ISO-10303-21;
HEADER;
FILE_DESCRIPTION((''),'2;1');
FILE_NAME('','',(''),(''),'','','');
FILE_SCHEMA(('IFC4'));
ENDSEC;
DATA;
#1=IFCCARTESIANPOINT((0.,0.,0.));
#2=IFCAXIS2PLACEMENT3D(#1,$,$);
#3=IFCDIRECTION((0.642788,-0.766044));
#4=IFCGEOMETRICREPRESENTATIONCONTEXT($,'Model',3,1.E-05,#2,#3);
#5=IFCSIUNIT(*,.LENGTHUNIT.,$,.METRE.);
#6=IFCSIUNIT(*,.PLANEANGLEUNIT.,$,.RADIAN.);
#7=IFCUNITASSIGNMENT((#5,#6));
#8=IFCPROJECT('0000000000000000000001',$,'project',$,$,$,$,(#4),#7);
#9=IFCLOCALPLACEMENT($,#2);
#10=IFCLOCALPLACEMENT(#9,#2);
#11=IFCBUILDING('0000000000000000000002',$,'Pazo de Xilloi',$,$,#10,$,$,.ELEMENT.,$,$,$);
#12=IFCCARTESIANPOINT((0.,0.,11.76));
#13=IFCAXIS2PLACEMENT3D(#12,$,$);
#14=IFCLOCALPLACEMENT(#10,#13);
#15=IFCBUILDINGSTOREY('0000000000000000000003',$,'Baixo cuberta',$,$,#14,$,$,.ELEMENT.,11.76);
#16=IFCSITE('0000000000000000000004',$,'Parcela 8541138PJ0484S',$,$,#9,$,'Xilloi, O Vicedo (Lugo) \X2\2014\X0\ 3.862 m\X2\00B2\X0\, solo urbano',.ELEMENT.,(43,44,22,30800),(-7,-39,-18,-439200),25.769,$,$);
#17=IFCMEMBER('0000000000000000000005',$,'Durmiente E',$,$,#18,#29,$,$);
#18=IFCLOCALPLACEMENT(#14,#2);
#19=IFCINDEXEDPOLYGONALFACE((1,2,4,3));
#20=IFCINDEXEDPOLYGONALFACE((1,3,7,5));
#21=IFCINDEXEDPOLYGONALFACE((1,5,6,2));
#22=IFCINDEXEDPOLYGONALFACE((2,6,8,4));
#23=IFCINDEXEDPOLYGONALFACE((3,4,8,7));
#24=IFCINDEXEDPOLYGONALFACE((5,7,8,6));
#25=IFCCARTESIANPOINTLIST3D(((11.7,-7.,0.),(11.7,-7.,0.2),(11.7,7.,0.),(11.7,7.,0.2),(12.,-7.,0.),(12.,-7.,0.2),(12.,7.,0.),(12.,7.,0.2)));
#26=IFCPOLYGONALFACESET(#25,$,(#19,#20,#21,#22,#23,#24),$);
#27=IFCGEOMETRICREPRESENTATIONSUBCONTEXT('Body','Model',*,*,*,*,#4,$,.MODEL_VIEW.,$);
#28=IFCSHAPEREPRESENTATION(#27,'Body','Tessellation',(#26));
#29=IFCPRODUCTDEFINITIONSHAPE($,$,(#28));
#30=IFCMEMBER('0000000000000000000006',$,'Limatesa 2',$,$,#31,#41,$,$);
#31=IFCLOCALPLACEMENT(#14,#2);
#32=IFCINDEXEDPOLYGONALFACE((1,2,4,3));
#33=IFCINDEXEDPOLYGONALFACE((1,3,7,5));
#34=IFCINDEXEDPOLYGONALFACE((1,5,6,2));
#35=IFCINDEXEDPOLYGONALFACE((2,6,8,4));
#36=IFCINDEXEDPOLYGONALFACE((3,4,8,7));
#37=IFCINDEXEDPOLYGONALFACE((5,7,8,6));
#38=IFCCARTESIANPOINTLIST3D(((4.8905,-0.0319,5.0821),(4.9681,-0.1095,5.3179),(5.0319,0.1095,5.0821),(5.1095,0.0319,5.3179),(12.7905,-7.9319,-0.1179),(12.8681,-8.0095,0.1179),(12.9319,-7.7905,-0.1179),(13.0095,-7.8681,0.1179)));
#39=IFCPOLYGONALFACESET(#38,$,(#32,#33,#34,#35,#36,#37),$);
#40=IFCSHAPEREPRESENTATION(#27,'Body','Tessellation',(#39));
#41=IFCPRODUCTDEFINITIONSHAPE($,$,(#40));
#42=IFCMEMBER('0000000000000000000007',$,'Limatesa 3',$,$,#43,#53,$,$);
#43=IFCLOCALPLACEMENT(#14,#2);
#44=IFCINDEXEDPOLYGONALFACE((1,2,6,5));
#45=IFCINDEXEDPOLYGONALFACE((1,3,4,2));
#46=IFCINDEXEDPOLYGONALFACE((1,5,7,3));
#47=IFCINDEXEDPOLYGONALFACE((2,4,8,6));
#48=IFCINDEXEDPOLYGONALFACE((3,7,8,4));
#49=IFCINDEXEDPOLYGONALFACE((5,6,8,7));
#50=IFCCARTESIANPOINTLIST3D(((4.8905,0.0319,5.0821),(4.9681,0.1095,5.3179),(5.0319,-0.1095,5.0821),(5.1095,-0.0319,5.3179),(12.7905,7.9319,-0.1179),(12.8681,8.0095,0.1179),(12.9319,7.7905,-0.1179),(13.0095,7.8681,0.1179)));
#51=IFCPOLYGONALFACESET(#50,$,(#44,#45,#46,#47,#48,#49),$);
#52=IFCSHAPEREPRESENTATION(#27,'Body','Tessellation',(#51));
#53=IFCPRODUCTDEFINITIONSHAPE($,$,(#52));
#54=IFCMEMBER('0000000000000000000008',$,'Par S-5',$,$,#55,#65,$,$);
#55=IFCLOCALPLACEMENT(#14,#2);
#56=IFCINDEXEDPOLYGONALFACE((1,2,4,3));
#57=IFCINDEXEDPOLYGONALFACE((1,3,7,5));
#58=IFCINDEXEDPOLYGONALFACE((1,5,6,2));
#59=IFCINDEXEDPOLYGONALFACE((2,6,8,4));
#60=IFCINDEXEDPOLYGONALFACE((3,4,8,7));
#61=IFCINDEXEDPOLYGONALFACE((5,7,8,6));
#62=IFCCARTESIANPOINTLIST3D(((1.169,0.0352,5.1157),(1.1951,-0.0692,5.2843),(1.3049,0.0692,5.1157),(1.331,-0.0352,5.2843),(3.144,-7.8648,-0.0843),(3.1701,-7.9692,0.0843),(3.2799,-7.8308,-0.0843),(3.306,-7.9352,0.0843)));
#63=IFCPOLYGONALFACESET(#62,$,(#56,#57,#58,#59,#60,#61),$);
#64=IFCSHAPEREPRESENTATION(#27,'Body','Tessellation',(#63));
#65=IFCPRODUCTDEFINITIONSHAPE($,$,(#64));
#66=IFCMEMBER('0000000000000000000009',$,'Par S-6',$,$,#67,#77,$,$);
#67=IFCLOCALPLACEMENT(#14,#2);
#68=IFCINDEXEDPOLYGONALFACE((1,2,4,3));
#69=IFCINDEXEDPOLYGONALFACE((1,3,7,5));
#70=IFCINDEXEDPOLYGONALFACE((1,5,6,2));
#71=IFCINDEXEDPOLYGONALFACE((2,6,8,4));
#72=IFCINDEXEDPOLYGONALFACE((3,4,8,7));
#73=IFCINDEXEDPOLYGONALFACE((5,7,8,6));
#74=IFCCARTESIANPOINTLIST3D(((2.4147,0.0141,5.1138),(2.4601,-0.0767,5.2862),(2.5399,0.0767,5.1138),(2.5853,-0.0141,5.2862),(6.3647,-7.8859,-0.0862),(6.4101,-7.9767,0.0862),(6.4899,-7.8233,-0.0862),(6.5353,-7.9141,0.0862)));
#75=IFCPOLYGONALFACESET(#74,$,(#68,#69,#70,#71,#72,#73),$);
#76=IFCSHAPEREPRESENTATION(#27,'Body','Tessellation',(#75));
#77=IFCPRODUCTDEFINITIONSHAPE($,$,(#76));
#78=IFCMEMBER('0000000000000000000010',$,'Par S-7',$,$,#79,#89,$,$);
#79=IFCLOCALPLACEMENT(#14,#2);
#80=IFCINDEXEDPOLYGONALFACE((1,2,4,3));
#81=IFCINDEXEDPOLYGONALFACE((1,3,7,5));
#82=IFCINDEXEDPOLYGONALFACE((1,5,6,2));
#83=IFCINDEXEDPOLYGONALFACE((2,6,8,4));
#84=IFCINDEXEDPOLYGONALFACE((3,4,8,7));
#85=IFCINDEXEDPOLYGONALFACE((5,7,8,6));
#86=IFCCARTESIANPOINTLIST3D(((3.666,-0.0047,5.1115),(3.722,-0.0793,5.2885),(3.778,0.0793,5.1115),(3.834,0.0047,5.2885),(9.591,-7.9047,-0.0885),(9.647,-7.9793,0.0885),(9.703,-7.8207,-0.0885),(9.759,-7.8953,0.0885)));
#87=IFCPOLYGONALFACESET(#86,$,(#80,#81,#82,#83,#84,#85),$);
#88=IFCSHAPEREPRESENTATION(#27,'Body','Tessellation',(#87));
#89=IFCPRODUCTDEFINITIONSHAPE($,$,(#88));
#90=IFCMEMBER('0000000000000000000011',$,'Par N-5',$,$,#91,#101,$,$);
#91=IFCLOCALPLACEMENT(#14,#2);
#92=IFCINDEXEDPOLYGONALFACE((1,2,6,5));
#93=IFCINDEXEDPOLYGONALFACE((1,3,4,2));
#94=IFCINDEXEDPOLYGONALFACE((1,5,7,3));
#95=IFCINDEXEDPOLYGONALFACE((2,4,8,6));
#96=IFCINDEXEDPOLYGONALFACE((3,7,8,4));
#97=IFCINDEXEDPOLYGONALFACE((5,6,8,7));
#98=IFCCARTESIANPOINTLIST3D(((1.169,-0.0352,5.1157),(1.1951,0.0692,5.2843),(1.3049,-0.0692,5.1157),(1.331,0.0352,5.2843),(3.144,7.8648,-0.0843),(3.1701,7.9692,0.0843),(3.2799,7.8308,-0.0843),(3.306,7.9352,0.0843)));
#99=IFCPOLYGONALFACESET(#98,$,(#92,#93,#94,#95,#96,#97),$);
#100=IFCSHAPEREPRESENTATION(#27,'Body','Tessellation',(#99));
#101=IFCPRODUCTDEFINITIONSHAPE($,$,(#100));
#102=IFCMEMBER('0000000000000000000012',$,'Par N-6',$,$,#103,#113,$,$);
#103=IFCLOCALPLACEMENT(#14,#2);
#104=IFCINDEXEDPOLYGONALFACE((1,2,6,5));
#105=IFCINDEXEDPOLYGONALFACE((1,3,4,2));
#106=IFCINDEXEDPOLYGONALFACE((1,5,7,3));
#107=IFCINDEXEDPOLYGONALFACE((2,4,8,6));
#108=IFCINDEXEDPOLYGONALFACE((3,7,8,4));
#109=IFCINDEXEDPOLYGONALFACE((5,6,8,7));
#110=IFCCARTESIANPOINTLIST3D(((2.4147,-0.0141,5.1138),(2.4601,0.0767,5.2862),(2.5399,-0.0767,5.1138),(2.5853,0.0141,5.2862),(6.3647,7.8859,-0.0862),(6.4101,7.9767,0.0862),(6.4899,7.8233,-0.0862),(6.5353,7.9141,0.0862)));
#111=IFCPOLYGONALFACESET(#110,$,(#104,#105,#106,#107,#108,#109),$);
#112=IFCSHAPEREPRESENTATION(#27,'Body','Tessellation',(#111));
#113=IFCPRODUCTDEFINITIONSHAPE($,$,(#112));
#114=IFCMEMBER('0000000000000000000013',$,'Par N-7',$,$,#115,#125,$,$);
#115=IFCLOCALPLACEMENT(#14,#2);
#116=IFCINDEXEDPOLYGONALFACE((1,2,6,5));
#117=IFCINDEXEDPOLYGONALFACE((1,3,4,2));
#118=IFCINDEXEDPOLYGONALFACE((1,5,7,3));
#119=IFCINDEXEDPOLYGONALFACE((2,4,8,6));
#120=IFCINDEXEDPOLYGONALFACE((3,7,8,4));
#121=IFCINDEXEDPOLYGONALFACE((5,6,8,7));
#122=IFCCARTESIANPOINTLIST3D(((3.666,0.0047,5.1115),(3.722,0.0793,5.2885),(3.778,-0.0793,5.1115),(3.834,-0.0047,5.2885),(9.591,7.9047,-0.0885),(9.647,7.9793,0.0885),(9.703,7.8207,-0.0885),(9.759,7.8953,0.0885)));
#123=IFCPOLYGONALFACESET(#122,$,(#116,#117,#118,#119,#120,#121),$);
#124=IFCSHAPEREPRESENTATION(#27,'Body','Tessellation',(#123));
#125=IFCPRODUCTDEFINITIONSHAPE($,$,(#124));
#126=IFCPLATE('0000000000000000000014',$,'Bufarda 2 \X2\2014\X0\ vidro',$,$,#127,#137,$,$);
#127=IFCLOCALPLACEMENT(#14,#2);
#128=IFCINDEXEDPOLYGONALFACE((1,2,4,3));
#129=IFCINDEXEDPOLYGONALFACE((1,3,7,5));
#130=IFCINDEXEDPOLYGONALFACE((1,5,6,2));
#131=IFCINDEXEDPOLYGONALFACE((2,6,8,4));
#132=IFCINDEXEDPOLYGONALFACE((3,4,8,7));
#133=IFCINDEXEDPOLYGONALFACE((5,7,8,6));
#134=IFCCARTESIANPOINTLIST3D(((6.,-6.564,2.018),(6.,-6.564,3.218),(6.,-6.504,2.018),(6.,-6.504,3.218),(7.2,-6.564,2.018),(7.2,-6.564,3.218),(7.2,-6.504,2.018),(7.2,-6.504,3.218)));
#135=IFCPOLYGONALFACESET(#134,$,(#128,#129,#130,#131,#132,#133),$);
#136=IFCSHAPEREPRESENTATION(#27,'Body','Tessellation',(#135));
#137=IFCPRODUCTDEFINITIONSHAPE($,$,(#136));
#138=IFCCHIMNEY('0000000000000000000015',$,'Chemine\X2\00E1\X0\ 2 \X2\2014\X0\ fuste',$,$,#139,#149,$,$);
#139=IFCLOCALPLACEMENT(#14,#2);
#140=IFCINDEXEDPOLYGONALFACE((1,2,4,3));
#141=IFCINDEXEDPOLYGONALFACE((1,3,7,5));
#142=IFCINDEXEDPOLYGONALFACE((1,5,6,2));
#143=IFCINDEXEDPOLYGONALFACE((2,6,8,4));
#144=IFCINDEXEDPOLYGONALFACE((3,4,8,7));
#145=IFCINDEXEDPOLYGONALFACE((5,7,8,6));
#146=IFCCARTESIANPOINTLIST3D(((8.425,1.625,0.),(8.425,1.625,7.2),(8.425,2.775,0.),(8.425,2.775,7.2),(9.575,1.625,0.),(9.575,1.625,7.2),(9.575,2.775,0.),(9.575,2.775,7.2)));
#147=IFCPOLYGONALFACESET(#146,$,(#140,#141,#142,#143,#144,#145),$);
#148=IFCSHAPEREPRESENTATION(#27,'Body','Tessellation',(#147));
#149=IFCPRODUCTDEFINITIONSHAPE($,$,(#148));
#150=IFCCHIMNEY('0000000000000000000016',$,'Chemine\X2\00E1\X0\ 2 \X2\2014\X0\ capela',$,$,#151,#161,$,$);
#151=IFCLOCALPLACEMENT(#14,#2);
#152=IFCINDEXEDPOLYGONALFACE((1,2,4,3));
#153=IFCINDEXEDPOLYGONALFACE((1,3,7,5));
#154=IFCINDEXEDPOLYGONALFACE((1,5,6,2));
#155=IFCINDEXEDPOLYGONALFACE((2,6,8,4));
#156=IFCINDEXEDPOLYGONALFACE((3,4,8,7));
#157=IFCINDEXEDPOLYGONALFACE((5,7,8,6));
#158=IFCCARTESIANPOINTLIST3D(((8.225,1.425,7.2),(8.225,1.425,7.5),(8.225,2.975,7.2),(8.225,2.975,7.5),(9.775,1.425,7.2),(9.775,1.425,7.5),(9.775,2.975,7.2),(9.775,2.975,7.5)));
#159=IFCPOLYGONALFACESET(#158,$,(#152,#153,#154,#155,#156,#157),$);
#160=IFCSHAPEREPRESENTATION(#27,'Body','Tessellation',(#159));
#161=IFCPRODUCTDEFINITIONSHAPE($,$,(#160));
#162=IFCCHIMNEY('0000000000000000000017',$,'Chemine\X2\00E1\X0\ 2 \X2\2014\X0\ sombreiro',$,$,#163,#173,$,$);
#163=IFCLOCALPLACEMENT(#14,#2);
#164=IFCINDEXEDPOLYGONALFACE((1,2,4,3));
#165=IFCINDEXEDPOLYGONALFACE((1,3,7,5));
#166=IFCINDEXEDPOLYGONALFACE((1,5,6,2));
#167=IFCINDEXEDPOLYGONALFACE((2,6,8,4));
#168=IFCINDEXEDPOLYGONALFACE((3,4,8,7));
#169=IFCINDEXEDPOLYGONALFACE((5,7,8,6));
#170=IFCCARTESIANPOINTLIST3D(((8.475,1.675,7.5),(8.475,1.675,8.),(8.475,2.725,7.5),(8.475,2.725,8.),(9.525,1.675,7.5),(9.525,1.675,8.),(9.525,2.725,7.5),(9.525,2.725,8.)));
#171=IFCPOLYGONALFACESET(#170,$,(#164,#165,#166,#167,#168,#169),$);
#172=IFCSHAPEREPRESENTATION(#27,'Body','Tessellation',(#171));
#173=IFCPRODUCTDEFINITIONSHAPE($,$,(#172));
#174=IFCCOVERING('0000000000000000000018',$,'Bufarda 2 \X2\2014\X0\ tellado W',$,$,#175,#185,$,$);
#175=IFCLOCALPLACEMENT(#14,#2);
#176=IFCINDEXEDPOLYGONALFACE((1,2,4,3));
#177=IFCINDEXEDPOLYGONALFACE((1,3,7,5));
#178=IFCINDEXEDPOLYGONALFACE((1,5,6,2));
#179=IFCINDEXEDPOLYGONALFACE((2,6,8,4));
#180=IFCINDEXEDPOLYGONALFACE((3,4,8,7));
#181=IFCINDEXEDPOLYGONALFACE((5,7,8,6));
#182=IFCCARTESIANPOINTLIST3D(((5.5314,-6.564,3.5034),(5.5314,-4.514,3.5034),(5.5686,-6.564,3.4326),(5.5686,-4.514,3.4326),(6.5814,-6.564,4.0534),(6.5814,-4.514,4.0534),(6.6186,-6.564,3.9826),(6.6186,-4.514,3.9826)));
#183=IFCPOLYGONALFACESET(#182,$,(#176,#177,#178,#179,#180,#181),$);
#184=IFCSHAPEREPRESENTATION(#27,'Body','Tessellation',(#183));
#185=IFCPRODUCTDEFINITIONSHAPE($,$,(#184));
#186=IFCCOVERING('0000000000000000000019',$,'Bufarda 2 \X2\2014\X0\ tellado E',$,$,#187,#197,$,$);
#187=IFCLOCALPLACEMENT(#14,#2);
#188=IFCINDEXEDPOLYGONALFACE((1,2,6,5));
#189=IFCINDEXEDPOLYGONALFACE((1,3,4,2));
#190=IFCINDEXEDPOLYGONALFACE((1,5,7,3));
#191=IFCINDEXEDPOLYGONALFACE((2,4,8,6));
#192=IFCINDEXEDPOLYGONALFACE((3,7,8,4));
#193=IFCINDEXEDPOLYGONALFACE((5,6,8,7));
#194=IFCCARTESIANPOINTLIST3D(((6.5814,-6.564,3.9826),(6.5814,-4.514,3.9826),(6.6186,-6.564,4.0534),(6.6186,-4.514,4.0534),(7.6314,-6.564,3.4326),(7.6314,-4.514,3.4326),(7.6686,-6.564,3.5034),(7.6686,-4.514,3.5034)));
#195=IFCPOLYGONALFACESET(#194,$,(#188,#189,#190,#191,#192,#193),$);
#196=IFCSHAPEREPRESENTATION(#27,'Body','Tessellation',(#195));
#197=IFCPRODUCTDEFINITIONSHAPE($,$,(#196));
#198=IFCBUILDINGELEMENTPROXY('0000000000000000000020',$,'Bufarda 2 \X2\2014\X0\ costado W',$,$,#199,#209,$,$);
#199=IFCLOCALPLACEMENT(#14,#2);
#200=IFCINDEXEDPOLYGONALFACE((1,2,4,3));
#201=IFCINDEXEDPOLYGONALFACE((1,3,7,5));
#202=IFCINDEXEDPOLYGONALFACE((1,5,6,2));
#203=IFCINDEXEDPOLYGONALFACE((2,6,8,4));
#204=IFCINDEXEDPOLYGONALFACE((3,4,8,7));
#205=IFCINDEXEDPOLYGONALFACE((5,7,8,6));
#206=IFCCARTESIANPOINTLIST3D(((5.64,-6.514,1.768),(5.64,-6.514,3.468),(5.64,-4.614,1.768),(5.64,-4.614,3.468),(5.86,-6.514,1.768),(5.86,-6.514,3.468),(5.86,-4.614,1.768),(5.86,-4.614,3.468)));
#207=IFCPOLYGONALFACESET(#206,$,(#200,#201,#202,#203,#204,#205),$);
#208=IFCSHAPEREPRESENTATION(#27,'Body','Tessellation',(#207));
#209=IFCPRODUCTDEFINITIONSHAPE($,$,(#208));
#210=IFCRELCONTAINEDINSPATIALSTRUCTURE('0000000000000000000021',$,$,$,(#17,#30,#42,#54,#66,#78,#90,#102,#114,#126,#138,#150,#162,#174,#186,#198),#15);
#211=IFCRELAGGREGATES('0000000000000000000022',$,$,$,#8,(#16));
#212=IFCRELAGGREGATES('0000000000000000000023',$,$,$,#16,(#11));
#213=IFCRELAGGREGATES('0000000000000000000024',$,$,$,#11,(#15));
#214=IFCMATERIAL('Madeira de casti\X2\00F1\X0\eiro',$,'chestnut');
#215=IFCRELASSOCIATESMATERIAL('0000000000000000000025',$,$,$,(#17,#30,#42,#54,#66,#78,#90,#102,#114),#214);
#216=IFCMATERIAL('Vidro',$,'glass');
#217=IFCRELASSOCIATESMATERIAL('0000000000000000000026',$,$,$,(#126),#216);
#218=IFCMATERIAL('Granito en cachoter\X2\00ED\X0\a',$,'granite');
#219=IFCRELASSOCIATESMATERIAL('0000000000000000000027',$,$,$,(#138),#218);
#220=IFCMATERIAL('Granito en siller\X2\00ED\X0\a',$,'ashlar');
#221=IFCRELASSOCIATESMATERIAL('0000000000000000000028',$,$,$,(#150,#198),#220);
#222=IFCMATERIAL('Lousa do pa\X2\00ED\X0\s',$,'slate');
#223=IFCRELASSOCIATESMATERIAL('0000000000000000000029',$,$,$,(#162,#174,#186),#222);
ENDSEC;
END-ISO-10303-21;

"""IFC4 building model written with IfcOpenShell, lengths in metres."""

from ifc_helpers import new_model, si_unit, direction, frame, origin, origin_2d, place, context, subcontext, project, spatial, polyline, rectangle, outline, extrude, material, element, save


model = new_model("IFC4")

# Units and contexts
model_context = context("Model", 3, precision=1e-05, world=origin(), true_north=direction((0.642788, -0.766044)))
body_context = subcontext(model_context, "Body", "Model", "MODEL_VIEW")
ifc_project = project(units=[si_unit("LENGTHUNIT", "METRE"), si_unit("PLANEANGLEUNIT", "RADIAN")], contexts=[model_context])

# Site, building, storey
site_placement = place(None, origin())
site = spatial("IfcSite", under=ifc_project, at=site_placement, Name="Parcela 8541138PJ0484S", LongName="Xilloi, O Vicedo (Lugo) — 3.862 m², solo urbano", CompositionType="ELEMENT", RefLatitude=(43, 44, 22, 30800), RefLongitude=(-7, -39, -18, -439200), RefElevation=25.769)
building_placement = place(site_placement, origin())
building = spatial("IfcBuilding", under=site, at=building_placement, Name="Pazo de Xilloi", CompositionType="ELEMENT")
storey_placement = place(building_placement, frame((0.0, 0.0, 11.76)))
storey = spatial("IfcBuildingStorey", under=building, at=storey_placement, Name="Baixo cuberta", CompositionType="ELEMENT", Elevation=11.76)

# Members
ifc_material_1 = material(Name="Madeira de castiñeiro", Category="chestnut")
member_1_placement = place(storey_placement, frame((11.85, 0.0, 0.1)))
element("IfcMember", 1, at=member_1_placement, inside=storey, material=ifc_material_1, Name="Durmiente E", context=body_context, shape_type="SweptSolid", body=[
    extrude(rectangle(XDim=0.3, YDim=14.0, at=origin_2d()), frame((0.0, 0.0, -0.1)), (0.0, 0.0, 1.0), 0.2),
])
for number, where, z_axis, x_axis, name in (
    (2, (8.95, -3.95, 2.6), (0.298378, -0.298378, 0.90661), (-0.64107, 0.64107, 0.42197), "Limatesa 2"),
    (3, (8.95, 3.95, 2.6), (0.298378, 0.298378, 0.90661), (-0.64107, -0.64107, 0.42197), "Limatesa 3"),
):
    element("IfcMember", number, at=place(storey_placement, frame(where, z_axis=z_axis, x_axis=x_axis)), inside=storey, material=ifc_material_1, Name=name, context=body_context, shape_type="SweptSolid", body=[
        extrude(rectangle(XDim=12.3231, YDim=0.2, at=origin_2d()), frame((0.0, 0.0, -0.13)), (0.0, 0.0, 1.0), 0.26),
    ])
member_2_placement = place(storey_placement, frame((2.2375, -3.95, 2.6), z_axis=(0.130533, -0.522132, 0.842816), x_axis=(-0.204413, 0.817652, 0.538201)))
element("IfcMember", 4, at=member_2_placement, inside=storey, material=ifc_material_1, Name="Par S-5", context=body_context, shape_type="SweptSolid", body=[
    extrude(rectangle(XDim=9.6618, YDim=0.14, at=origin_2d()), frame((0.0, 0.0, -0.1)), (0.0, 0.0, 1.0), 0.2),
])
member_3_placement = place(storey_placement, frame((4.475, -3.95, 2.6), z_axis=(0.22689, -0.45378, 0.861745), x_axis=(-0.385384, 0.770768, 0.507341)))
element("IfcMember", 5, at=member_3_placement, inside=storey, material=ifc_material_1, Name="Par S-6", context=body_context, shape_type="SweptSolid", body=[
    extrude(rectangle(XDim=10.2495, YDim=0.14, at=origin_2d()), frame((0.0, 0.0, -0.1)), (0.0, 0.0, 1.0), 0.2),
])
member_4_placement = place(storey_placement, frame((6.7125, -3.95, 2.6), z_axis=(0.279559, -0.372745, 0.884821), x_axis=(-0.530893, 0.707857, 0.465931)))
element("IfcMember", 6, at=member_4_placement, inside=storey, material=ifc_material_1, Name="Par S-7", context=body_context, shape_type="SweptSolid", body=[
    extrude(rectangle(XDim=11.1604, YDim=0.14, at=origin_2d()), frame((0.0, 0.0, -0.1)), (0.0, 0.0, 1.0), 0.2),
])
member_5_placement = place(storey_placement, frame((2.2375, 3.95, 2.6), z_axis=(0.130533, 0.522132, 0.842816), x_axis=(-0.204413, -0.817652, 0.538201)))
element("IfcMember", 7, at=member_5_placement, inside=storey, material=ifc_material_1, Name="Par N-5", context=body_context, shape_type="SweptSolid", body=[
    extrude(rectangle(XDim=9.6618, YDim=0.14, at=origin_2d()), frame((0.0, 0.0, -0.1)), (0.0, 0.0, 1.0), 0.2),
])
member_6_placement = place(storey_placement, frame((4.475, 3.95, 2.6), z_axis=(0.22689, 0.45378, 0.861745), x_axis=(-0.385384, -0.770768, 0.507341)))
element("IfcMember", 8, at=member_6_placement, inside=storey, material=ifc_material_1, Name="Par N-6", context=body_context, shape_type="SweptSolid", body=[
    extrude(rectangle(XDim=10.2495, YDim=0.14, at=origin_2d()), frame((0.0, 0.0, -0.1)), (0.0, 0.0, 1.0), 0.2),
])
member_7_placement = place(storey_placement, frame((6.7125, 3.95, 2.6), z_axis=(0.279559, 0.372745, 0.884821), x_axis=(-0.530893, -0.707857, 0.465931)))
element("IfcMember", 9, at=member_7_placement, inside=storey, material=ifc_material_1, Name="Par N-7", context=body_context, shape_type="SweptSolid", body=[
    extrude(rectangle(XDim=11.1604, YDim=0.14, at=origin_2d()), frame((0.0, 0.0, -0.1)), (0.0, 0.0, 1.0), 0.2),
])

# Plate
ifc_material_2 = material(Name="Vidro", Category="glass")
plate_placement = place(storey_placement, frame((6.6, -6.534, 2.618)))
element("IfcPlate", 10, at=plate_placement, inside=storey, material=ifc_material_2, Name="Bufarda 2 — vidro", context=body_context, shape_type="SweptSolid", body=[
    extrude(rectangle(XDim=1.2, YDim=0.06, at=origin_2d()), frame((0.0, 0.0, -0.6)), (0.0, 0.0, 1.0), 1.2),
])

# Chimneys
ifc_material_3 = material(Name="Granito en cachotería", Category="granite")
chimney_1_placement = place(storey_placement, frame((9.0, 2.2, 3.6)))
element("IfcChimney", 11, at=chimney_1_placement, inside=storey, material=ifc_material_3, Name="Chemineá 2 — fuste", context=body_context, shape_type="SweptSolid", body=[
    extrude(rectangle(XDim=1.15, YDim=1.15, at=origin_2d()), frame((0.0, 0.0, -3.6)), (0.0, 0.0, 1.0), 7.2),
])
ifc_material_4 = material(Name="Granito en sillería", Category="ashlar")
chimney_2_placement = place(storey_placement, frame((9.0, 2.2, 7.35)))
element("IfcChimney", 12, at=chimney_2_placement, inside=storey, material=ifc_material_4, Name="Chemineá 2 — capela", context=body_context, shape_type="SweptSolid", body=[
    extrude(rectangle(XDim=1.55, YDim=1.55, at=origin_2d()), frame((0.0, 0.0, -0.15)), (0.0, 0.0, 1.0), 0.3),
])
ifc_material_5 = material(Name="Lousa do país", Category="slate")
chimney_3_placement = place(storey_placement, frame((9.0, 2.2, 7.75)))
element("IfcChimney", 13, at=chimney_3_placement, inside=storey, material=ifc_material_5, Name="Chemineá 2 — sombreiro", context=body_context, shape_type="SweptSolid", body=[
    extrude(rectangle(XDim=1.05, YDim=1.05, at=origin_2d()), frame((0.0, 0.0, -0.25)), (0.0, 0.0, 1.0), 0.5),
])

# Coverings
covering_1_placement = place(storey_placement, frame((6.075, -5.539, 3.743), z_axis=(-0.464007, 0.0, 0.885832), x_axis=(0.0, -1.0, 0.0)))
element("IfcCovering", 14, at=covering_1_placement, inside=storey, material=ifc_material_5, Name="Bufarda 2 — tellado W", context=body_context, shape_type="SweptSolid", body=[
    extrude(outline(polyline([(1.025, -0.5927), (1.025, 0.5927), (-1.025, 0.5927), (-1.025, -0.5927), (1.025, -0.5927)])), frame((0.0, 0.0, -0.04)), (0.0, 0.0, 1.0), 0.08),
])
covering_2_placement = place(storey_placement, frame((7.125, -5.539, 3.743), z_axis=(-0.464007, 0.0, -0.885832), x_axis=(0.0, -1.0, 0.0)))
element("IfcCovering", 15, at=covering_2_placement, inside=storey, material=ifc_material_5, Name="Bufarda 2 — tellado E", context=body_context, shape_type="SweptSolid", body=[
    extrude(outline(polyline([(1.025, -0.5927), (1.025, 0.5927), (-1.025, 0.5927), (-1.025, -0.5927), (1.025, -0.5927)])), frame((0.0, 0.0, -0.04)), (0.0, 0.0, 1.0), 0.08),
])

# Building element proxy
for number, where, name in (
    (16, (5.75, -5.564, 2.618), "Bufarda 2 — costado W"),
):
    element("IfcBuildingElementProxy", number, at=place(storey_placement, frame(where)), inside=storey, material=ifc_material_4, Name=name, context=body_context, shape_type="SweptSolid", body=[
        extrude(rectangle(XDim=0.22, YDim=1.9, at=origin_2d()), frame((0.0, 0.0, -0.85)), (0.0, 0.0, 1.0), 1.7),
    ])

save(model, "model.ifc")
